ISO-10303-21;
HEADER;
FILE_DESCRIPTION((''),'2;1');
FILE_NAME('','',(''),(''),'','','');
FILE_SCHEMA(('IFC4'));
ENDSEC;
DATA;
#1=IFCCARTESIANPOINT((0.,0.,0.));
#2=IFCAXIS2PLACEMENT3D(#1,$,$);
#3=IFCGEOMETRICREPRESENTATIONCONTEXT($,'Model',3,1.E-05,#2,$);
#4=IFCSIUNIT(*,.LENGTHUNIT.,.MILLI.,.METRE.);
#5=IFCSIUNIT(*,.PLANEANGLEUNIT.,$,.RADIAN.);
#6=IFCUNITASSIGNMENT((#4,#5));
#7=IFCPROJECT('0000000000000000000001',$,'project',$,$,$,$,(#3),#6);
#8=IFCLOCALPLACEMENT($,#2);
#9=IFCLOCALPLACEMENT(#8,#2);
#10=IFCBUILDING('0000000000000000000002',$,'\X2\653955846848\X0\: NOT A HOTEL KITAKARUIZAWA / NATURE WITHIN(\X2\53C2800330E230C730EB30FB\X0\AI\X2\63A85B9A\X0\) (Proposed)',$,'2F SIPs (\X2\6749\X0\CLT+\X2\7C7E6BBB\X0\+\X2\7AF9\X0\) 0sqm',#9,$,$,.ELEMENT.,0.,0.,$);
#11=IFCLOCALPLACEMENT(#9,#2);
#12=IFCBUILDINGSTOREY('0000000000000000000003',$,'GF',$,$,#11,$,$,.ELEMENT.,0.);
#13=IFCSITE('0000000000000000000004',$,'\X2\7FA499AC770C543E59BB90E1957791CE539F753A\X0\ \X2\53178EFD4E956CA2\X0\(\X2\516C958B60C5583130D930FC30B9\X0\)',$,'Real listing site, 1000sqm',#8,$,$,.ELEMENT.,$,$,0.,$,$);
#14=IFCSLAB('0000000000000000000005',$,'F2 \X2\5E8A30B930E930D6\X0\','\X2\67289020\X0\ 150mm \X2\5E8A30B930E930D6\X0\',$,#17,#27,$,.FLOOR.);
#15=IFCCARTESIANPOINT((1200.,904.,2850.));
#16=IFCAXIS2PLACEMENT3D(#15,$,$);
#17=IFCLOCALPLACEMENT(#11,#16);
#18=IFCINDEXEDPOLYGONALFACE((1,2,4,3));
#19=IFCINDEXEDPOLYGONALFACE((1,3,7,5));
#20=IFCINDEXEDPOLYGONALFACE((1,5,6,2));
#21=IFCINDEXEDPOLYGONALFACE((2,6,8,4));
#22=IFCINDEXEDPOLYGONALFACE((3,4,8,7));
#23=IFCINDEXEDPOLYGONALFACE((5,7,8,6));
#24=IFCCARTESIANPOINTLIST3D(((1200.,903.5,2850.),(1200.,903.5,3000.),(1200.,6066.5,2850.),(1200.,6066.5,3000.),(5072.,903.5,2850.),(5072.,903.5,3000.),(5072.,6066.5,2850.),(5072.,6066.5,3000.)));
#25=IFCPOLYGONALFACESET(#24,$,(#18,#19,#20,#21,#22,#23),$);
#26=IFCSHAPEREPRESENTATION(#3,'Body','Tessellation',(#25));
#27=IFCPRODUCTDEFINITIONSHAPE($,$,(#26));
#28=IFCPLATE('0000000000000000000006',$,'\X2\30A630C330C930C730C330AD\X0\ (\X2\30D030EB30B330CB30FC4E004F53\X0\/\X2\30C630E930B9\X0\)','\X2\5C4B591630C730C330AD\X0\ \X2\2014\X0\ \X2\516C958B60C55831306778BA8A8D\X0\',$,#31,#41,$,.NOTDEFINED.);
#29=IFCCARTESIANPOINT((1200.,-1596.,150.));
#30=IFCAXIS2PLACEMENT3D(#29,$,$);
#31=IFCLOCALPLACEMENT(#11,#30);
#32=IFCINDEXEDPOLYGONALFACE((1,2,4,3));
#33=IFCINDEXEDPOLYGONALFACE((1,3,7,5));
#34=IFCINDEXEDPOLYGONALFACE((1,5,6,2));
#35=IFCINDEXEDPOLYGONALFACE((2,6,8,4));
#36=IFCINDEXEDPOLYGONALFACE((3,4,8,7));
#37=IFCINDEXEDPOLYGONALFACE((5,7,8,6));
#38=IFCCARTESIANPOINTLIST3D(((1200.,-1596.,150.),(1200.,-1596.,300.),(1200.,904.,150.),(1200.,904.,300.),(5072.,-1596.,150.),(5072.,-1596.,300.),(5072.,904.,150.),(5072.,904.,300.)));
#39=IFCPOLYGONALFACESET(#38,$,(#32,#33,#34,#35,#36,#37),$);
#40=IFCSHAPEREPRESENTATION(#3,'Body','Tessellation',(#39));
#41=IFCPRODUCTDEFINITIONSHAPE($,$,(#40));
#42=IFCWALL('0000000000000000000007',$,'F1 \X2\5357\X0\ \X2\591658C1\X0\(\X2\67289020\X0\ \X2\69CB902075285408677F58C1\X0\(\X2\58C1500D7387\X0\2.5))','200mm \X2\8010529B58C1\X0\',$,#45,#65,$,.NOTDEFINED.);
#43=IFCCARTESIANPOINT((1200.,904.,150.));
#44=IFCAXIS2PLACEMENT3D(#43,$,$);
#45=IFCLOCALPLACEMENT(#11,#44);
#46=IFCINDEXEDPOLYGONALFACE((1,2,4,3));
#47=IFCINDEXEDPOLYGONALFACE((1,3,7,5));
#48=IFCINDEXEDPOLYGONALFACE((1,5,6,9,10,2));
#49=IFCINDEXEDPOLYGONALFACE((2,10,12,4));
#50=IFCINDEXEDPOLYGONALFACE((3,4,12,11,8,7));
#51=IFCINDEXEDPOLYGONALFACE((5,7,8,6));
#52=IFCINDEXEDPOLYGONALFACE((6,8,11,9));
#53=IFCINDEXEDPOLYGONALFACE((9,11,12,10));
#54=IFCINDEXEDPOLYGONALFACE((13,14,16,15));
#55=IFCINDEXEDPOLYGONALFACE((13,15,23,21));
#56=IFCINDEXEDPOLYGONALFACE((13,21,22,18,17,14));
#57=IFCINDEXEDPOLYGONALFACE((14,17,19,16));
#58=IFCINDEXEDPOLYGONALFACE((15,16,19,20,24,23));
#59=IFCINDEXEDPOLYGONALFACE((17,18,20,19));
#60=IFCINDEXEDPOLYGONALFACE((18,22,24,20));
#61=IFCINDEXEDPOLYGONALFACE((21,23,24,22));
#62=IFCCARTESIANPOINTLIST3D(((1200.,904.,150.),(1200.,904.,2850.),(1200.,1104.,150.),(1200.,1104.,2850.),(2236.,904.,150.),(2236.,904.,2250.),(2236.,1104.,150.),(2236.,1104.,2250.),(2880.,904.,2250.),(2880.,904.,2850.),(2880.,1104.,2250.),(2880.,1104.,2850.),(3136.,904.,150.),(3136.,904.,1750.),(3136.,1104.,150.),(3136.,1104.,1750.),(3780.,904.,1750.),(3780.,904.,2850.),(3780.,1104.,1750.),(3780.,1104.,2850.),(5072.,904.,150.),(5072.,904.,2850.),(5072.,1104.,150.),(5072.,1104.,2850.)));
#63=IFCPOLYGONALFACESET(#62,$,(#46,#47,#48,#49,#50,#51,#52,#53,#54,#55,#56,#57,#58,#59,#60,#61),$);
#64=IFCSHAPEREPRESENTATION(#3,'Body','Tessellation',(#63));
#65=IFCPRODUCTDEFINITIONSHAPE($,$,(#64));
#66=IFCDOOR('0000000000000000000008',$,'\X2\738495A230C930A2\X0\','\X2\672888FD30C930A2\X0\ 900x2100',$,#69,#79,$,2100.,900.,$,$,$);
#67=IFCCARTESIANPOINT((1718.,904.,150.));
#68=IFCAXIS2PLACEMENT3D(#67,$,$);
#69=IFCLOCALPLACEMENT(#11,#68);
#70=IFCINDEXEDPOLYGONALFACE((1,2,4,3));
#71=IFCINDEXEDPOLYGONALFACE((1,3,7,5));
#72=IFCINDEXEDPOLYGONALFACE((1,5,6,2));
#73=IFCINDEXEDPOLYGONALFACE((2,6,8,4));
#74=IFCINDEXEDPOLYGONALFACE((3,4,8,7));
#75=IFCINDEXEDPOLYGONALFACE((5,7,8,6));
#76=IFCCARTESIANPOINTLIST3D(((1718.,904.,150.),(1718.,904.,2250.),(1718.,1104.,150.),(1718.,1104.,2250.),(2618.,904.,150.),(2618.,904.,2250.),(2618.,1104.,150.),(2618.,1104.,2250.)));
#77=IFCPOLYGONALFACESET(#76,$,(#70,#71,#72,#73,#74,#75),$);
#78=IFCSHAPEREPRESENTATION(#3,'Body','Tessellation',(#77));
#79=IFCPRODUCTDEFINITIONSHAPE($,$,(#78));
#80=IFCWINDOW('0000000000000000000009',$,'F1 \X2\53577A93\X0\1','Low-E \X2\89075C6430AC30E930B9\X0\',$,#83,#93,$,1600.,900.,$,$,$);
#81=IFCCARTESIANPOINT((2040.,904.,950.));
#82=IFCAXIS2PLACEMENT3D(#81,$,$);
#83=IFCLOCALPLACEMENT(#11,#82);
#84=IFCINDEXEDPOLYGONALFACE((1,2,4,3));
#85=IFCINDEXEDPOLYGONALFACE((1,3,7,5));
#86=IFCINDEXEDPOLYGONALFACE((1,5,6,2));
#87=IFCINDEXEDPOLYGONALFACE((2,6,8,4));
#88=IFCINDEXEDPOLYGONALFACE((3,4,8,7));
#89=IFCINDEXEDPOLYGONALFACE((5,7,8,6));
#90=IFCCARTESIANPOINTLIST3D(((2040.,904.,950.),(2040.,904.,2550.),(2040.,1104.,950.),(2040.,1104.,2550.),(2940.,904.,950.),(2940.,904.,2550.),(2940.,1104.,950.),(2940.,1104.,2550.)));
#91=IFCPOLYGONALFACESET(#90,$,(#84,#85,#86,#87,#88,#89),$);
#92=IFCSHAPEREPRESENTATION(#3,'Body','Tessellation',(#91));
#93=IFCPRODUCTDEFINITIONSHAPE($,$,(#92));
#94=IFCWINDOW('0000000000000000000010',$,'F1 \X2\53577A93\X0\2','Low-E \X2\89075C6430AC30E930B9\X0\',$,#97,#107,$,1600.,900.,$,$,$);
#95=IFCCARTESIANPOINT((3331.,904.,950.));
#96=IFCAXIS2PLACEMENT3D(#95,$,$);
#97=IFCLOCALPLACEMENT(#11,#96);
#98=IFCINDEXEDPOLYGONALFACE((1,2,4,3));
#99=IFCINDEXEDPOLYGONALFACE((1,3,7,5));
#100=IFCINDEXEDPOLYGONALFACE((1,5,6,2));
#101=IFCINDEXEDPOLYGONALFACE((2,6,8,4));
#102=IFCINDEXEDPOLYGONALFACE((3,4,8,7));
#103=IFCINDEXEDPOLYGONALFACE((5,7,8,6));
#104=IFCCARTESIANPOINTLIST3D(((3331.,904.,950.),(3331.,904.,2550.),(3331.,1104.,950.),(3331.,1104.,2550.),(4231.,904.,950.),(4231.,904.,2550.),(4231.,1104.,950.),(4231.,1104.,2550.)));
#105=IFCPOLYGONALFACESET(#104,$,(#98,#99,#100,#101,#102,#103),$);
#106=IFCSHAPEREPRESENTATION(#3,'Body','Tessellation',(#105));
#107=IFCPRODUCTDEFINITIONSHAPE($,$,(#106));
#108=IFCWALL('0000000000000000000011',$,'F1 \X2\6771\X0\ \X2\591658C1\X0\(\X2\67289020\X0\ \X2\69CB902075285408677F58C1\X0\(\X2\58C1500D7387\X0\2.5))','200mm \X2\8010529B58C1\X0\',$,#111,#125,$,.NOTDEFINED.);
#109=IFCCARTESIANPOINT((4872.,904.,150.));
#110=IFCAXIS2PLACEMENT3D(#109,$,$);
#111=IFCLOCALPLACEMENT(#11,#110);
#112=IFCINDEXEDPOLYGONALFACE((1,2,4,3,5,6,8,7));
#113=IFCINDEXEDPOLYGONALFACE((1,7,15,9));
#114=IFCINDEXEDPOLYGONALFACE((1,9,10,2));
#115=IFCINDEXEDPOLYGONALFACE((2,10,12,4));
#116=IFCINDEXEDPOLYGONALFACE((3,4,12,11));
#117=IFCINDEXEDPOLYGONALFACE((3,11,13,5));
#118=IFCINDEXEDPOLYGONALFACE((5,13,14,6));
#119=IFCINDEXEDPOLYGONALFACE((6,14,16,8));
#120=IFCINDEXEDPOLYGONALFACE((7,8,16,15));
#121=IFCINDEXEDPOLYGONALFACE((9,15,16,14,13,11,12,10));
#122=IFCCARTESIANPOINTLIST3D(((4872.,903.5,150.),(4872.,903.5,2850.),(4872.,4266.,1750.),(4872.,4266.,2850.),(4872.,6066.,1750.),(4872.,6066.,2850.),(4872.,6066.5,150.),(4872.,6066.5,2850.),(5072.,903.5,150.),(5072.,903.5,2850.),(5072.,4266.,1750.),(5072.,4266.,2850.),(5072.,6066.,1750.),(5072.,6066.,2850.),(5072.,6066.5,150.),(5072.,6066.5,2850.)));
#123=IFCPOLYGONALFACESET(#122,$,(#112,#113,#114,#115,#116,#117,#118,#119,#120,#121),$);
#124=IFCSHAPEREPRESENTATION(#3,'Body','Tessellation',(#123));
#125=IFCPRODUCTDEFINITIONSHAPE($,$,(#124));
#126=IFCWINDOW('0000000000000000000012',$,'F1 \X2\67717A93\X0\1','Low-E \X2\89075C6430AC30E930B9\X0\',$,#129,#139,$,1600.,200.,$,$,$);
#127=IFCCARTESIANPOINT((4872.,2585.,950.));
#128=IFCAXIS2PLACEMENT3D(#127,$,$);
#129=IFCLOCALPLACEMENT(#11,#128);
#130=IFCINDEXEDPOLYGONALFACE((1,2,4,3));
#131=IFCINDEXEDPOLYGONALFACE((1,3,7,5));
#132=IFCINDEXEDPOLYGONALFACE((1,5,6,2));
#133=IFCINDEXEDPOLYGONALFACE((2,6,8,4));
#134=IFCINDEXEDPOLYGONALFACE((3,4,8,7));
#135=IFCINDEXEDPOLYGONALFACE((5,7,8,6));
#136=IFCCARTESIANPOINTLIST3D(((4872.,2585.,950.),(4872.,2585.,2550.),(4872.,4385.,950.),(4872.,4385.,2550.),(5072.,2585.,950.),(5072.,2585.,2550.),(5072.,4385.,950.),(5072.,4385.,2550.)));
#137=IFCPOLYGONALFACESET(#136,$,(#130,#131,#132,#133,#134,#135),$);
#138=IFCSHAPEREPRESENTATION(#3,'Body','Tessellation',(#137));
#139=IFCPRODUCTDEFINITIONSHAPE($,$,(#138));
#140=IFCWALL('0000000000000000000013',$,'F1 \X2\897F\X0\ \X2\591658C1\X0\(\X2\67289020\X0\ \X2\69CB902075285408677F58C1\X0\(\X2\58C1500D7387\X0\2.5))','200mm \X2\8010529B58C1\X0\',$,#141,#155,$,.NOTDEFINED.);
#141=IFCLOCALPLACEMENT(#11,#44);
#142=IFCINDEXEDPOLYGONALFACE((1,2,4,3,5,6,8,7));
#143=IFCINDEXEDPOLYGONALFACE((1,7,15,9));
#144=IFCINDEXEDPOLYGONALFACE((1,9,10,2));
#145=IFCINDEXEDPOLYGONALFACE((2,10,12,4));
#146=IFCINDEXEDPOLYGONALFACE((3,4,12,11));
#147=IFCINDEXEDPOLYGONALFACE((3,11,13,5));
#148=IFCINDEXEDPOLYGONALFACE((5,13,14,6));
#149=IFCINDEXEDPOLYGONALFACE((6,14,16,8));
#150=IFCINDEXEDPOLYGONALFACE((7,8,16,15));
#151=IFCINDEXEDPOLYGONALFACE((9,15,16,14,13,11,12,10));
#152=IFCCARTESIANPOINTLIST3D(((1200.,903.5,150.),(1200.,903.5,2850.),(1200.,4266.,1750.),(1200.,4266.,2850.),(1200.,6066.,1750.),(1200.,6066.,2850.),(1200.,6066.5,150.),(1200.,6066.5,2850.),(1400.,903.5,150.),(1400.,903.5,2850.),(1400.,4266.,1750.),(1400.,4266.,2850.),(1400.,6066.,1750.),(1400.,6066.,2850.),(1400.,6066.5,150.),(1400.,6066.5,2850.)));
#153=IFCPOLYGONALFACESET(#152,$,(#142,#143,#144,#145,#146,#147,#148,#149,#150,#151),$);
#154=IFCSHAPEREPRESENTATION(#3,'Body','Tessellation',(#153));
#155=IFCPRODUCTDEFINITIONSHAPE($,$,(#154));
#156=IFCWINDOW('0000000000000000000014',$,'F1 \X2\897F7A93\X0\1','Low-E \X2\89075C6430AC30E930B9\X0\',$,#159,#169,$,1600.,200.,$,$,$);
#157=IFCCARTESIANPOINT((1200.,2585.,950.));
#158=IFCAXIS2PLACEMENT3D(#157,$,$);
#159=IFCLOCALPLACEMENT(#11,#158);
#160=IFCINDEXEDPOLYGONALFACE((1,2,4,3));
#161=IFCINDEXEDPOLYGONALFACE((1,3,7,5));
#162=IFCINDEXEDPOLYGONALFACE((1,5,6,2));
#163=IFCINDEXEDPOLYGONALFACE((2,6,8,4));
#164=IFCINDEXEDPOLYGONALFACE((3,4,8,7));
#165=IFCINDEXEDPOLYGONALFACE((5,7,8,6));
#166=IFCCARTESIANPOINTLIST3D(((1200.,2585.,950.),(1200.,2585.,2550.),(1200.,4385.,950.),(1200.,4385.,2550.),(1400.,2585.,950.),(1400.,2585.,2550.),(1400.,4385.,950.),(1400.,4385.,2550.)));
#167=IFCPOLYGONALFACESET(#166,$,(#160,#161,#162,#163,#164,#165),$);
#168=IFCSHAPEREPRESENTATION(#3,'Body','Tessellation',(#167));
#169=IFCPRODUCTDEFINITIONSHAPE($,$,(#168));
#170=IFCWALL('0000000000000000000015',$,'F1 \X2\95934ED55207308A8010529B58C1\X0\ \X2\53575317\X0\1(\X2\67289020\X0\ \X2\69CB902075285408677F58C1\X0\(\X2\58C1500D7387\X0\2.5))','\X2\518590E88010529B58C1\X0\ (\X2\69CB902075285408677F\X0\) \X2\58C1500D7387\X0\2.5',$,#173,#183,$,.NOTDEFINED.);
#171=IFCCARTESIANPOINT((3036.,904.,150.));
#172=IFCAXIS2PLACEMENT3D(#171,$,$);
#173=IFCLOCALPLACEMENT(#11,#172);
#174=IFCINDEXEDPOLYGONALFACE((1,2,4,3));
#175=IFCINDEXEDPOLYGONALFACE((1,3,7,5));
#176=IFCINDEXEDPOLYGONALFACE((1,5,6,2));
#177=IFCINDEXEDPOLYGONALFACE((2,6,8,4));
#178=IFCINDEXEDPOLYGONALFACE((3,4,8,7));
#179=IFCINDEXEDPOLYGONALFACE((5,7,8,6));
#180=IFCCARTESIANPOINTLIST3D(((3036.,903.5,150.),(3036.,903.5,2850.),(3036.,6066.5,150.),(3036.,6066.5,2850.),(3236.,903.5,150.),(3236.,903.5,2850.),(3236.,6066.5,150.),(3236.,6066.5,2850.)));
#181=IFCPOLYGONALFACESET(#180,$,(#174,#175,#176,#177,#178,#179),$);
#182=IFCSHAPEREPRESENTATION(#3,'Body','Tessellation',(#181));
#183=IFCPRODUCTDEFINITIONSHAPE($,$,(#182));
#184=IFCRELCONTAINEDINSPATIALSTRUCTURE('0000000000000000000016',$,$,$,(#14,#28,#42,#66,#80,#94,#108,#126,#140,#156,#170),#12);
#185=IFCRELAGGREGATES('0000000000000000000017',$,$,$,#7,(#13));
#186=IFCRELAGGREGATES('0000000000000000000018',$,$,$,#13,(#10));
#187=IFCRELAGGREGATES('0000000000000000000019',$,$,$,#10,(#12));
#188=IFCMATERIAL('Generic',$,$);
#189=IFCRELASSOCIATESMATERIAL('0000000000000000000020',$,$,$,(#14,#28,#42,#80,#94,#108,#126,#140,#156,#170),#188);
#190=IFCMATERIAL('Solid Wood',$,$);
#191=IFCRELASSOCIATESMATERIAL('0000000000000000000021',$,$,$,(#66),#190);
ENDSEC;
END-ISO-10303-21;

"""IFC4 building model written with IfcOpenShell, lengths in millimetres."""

from ifc_helpers import new_model, si_unit, frame, frame_2d, origin, place, context, project, spatial, rectangle, extrude, material, element, fill, save


model = new_model("IFC4")

# Units and contexts
model_context = context("Model", 3, precision=1e-05, world=origin())
ifc_project = project(units=[si_unit("LENGTHUNIT", "METRE", prefix="MILLI"), si_unit("PLANEANGLEUNIT", "RADIAN")], contexts=[model_context])

# Site, building, storey
site_placement = place(None, origin())
site = spatial("IfcSite", under=ifc_project, at=site_placement, Name="群馬県吾妻郡長野原町 北軽井沢(公開情報ベース)", ObjectType="Real listing site, 1000sqm", CompositionType="ELEMENT", RefElevation=0.0)
building_placement = place(site_placement, origin())
building = spatial("IfcBuilding", under=site, at=building_placement, Name="改善案: NOT A HOTEL KITAKARUIZAWA / NATURE WITHIN(参考モデル・AI推定) (Proposed)", ObjectType="2F SIPs (杉CLT+籾殻+竹) 0sqm", CompositionType="ELEMENT", ElevationOfRefHeight=0.0, ElevationOfTerrain=0.0)
storey_placement = place(building_placement, origin())
storey = spatial("IfcBuildingStorey", under=building, at=storey_placement, Name="GF", CompositionType="ELEMENT", Elevation=0.0)

# Slab
ifc_material_1 = material(Name="Generic")
slab_1_placement = place(storey_placement, frame((1200.0, 904.0, 2850.0)))
element("IfcSlab", 1, at=slab_1_placement, inside=storey, material=ifc_material_1, Name="F2 床スラブ", Description="木造 150mm 床スラブ", PredefinedType="FLOOR", context=model_context, shape_type="SweptSolid", body=[
    extrude(rectangle(XDim=3872.0, YDim=5163.0, at=frame_2d((1936.0, 2581.0))), frame((1200.0, 904.0, 2850.0)), (0.0, 0.0, 1.0), 150.0),
])

# Plate
plate_placement = place(storey_placement, frame((1200.0, -1596.0, 150.0)))
element("IfcPlate", 2, at=plate_placement, inside=storey, material=ifc_material_1, Name="ウッドデッキ (バルコニー一体/テラス)", Description="屋外デッキ — 公開情報で確認", PredefinedType="NOTDEFINED", context=model_context, shape_type="SweptSolid", body=[
    extrude(rectangle(XDim=3872.0, YDim=2500.0, at=frame_2d((1936.0, 1250.0))), frame((1200.0, -1596.0, 150.0)), (0.0, 0.0, 1.0), 150.0),
])

# Wall, openings, door, windows
wall_1_placement = place(storey_placement, frame((1200.0, 904.0, 150.0)))
wall_1 = element("IfcWall", 3, at=wall_1_placement, inside=storey, material=ifc_material_1, Name="F1 南 外壁(木造 構造用合板壁(壁倍率2.5))", Description="200mm 耐力壁", PredefinedType="NOTDEFINED", context=model_context, shape_type="SweptSolid", body=[
    extrude(rectangle(XDim=3872.0, YDim=200.0, at=frame_2d((1936.0, 100.0))), frame((1200.0, 904.0, 150.0)), (0.0, 0.0, 1.0), 2700.0),
])
opening_1_placement = place(storey_placement, frame((1718.0, 904.0, 150.0)))
opening_1 = element("IfcOpeningElement", 4, at=opening_1_placement, cuts=wall_1, PredefinedType="NOTDEFINED", context=model_context, shape_type="SweptSolid", body=[
    extrude(rectangle(XDim=900.0, YDim=200.0, at=frame_2d((450.0, 100.0))), frame((1718.0, 904.0, 150.0)), (0.0, 0.0, 1.0), 2100.0),
])
opening_2_placement = place(storey_placement, frame((2040.0, 904.0, 950.0)))
opening_2 = element("IfcOpeningElement", 5, at=opening_2_placement, cuts=wall_1, PredefinedType="NOTDEFINED", context=model_context, shape_type="SweptSolid", body=[
    extrude(rectangle(XDim=900.0, YDim=200.0, at=frame_2d((450.0, 100.0))), frame((2040.0, 904.0, 950.0)), (0.0, 0.0, 1.0), 1600.0),
])
opening_3_placement = place(storey_placement, frame((3331.0, 904.0, 950.0)))
opening_3 = element("IfcOpeningElement", 6, at=opening_3_placement, cuts=wall_1, PredefinedType="NOTDEFINED", context=model_context, shape_type="SweptSolid", body=[
    extrude(rectangle(XDim=900.0, YDim=200.0, at=frame_2d((450.0, 100.0))), frame((3331.0, 904.0, 950.0)), (0.0, 0.0, 1.0), 1600.0),
])
ifc_material_2 = material(Name="Solid Wood")
door_placement = place(storey_placement, frame((1718.0, 904.0, 150.0)))
door = element("IfcDoor", 7, at=door_placement, inside=storey, material=ifc_material_2, Name="玄関ドア", Description="木製ドア 900x2100", OverallHeight=2100.0, OverallWidth=900.0, context=model_context, shape_type="SweptSolid", body=[
    extrude(rectangle(XDim=900.0, YDim=200.0, at=frame_2d((450.0, 100.0))), frame((1718.0, 904.0, 150.0)), (0.0, 0.0, 1.0), 2100.0),
])
fill(opening_1, door)
window_1_placement = place(storey_placement, frame((2040.0, 904.0, 950.0)))
window_1 = element("IfcWindow", 8, at=window_1_placement, inside=storey, material=ifc_material_1, Name="F1 南窓1", Description="Low-E 複層ガラス", OverallHeight=1600.0, OverallWidth=900.0, context=model_context, shape_type="SweptSolid", body=[
    extrude(rectangle(XDim=900.0, YDim=200.0, at=frame_2d((450.0, 100.0))), frame((2040.0, 904.0, 950.0)), (0.0, 0.0, 1.0), 1600.0),
])
fill(opening_2, window_1)
window_2_placement = place(storey_placement, frame((3331.0, 904.0, 950.0)))
window_2 = element("IfcWindow", 9, at=window_2_placement, inside=storey, material=ifc_material_1, Name="F1 南窓2", Description="Low-E 複層ガラス", OverallHeight=1600.0, OverallWidth=900.0, context=model_context, shape_type="SweptSolid", body=[
    extrude(rectangle(XDim=900.0, YDim=200.0, at=frame_2d((450.0, 100.0))), frame((3331.0, 904.0, 950.0)), (0.0, 0.0, 1.0), 1600.0),
])
fill(opening_3, window_2)

# Walls, openings, windows
wall_2_placement = place(storey_placement, frame((4872.0, 904.0, 150.0)))
wall_2 = element("IfcWall", 10, at=wall_2_placement, inside=storey, material=ifc_material_1, Name="F1 東 外壁(木造 構造用合板壁(壁倍率2.5))", Description="200mm 耐力壁", PredefinedType="NOTDEFINED", context=model_context, shape_type="SweptSolid", body=[
    extrude(rectangle(XDim=200.0, YDim=5163.0, at=frame_2d((100.0, 2581.0))), frame((4872.0, 904.0, 150.0)), (0.0, 0.0, 1.0), 2700.0),
])
opening_4_placement = place(storey_placement, frame((4872.0, 2585.0, 950.0)))
opening_4 = element("IfcOpeningElement", 11, at=opening_4_placement, cuts=wall_2, PredefinedType="NOTDEFINED", context=model_context, shape_type="SweptSolid", body=[
    extrude(rectangle(XDim=200.0, YDim=1800.0, at=frame_2d((100.0, 900.0))), frame((4872.0, 2585.0, 950.0)), (0.0, 0.0, 1.0), 1600.0),
])
window_3_placement = place(storey_placement, frame((4872.0, 2585.0, 950.0)))
window_3 = element("IfcWindow", 12, at=window_3_placement, inside=storey, material=ifc_material_1, Name="F1 東窓1", Description="Low-E 複層ガラス", OverallHeight=1600.0, OverallWidth=200.0, context=model_context, shape_type="SweptSolid", body=[
    extrude(rectangle(XDim=200.0, YDim=1800.0, at=frame_2d((100.0, 900.0))), frame((4872.0, 2585.0, 950.0)), (0.0, 0.0, 1.0), 1600.0),
])
fill(opening_4, window_3)
wall_3_placement = place(storey_placement, frame((1200.0, 904.0, 150.0)))
wall_3 = element("IfcWall", 13, at=wall_3_placement, inside=storey, material=ifc_material_1, Name="F1 西 外壁(木造 構造用合板壁(壁倍率2.5))", Description="200mm 耐力壁", PredefinedType="NOTDEFINED", context=model_context, shape_type="SweptSolid", body=[
    extrude(rectangle(XDim=200.0, YDim=5163.0, at=frame_2d((100.0, 2581.0))), frame((1200.0, 904.0, 150.0)), (0.0, 0.0, 1.0), 2700.0),
])
opening_5_placement = place(storey_placement, frame((1200.0, 2585.0, 950.0)))
opening_5 = element("IfcOpeningElement", 14, at=opening_5_placement, cuts=wall_3, PredefinedType="NOTDEFINED", context=model_context, shape_type="SweptSolid", body=[
    extrude(rectangle(XDim=200.0, YDim=1800.0, at=frame_2d((100.0, 900.0))), frame((1200.0, 2585.0, 950.0)), (0.0, 0.0, 1.0), 1600.0),
])
window_4_placement = place(storey_placement, frame((1200.0, 2585.0, 950.0)))
window_4 = element("IfcWindow", 15, at=window_4_placement, inside=storey, material=ifc_material_1, Name="F1 西窓1", Description="Low-E 複層ガラス", OverallHeight=1600.0, OverallWidth=200.0, context=model_context, shape_type="SweptSolid", body=[
    extrude(rectangle(XDim=200.0, YDim=1800.0, at=frame_2d((100.0, 900.0))), frame((1200.0, 2585.0, 950.0)), (0.0, 0.0, 1.0), 1600.0),
])
fill(opening_5, window_4)

# Wall
wall_4_placement = place(storey_placement, frame((3036.0, 904.0, 150.0)))
element("IfcWall", 16, at=wall_4_placement, inside=storey, material=ifc_material_1, Name="F1 間仕切り耐力壁 南北1(木造 構造用合板壁(壁倍率2.5))", Description="内部耐力壁 (構造用合板) 壁倍率2.5", PredefinedType="NOTDEFINED", context=model_context, shape_type="SweptSolid", body=[
    extrude(rectangle(XDim=200.0, YDim=5163.0, at=frame_2d((100.0, 2581.0))), frame((3036.0, 904.0, 150.0)), (0.0, 0.0, 1.0), 2700.0),
])

save(model, "model.ifc")
